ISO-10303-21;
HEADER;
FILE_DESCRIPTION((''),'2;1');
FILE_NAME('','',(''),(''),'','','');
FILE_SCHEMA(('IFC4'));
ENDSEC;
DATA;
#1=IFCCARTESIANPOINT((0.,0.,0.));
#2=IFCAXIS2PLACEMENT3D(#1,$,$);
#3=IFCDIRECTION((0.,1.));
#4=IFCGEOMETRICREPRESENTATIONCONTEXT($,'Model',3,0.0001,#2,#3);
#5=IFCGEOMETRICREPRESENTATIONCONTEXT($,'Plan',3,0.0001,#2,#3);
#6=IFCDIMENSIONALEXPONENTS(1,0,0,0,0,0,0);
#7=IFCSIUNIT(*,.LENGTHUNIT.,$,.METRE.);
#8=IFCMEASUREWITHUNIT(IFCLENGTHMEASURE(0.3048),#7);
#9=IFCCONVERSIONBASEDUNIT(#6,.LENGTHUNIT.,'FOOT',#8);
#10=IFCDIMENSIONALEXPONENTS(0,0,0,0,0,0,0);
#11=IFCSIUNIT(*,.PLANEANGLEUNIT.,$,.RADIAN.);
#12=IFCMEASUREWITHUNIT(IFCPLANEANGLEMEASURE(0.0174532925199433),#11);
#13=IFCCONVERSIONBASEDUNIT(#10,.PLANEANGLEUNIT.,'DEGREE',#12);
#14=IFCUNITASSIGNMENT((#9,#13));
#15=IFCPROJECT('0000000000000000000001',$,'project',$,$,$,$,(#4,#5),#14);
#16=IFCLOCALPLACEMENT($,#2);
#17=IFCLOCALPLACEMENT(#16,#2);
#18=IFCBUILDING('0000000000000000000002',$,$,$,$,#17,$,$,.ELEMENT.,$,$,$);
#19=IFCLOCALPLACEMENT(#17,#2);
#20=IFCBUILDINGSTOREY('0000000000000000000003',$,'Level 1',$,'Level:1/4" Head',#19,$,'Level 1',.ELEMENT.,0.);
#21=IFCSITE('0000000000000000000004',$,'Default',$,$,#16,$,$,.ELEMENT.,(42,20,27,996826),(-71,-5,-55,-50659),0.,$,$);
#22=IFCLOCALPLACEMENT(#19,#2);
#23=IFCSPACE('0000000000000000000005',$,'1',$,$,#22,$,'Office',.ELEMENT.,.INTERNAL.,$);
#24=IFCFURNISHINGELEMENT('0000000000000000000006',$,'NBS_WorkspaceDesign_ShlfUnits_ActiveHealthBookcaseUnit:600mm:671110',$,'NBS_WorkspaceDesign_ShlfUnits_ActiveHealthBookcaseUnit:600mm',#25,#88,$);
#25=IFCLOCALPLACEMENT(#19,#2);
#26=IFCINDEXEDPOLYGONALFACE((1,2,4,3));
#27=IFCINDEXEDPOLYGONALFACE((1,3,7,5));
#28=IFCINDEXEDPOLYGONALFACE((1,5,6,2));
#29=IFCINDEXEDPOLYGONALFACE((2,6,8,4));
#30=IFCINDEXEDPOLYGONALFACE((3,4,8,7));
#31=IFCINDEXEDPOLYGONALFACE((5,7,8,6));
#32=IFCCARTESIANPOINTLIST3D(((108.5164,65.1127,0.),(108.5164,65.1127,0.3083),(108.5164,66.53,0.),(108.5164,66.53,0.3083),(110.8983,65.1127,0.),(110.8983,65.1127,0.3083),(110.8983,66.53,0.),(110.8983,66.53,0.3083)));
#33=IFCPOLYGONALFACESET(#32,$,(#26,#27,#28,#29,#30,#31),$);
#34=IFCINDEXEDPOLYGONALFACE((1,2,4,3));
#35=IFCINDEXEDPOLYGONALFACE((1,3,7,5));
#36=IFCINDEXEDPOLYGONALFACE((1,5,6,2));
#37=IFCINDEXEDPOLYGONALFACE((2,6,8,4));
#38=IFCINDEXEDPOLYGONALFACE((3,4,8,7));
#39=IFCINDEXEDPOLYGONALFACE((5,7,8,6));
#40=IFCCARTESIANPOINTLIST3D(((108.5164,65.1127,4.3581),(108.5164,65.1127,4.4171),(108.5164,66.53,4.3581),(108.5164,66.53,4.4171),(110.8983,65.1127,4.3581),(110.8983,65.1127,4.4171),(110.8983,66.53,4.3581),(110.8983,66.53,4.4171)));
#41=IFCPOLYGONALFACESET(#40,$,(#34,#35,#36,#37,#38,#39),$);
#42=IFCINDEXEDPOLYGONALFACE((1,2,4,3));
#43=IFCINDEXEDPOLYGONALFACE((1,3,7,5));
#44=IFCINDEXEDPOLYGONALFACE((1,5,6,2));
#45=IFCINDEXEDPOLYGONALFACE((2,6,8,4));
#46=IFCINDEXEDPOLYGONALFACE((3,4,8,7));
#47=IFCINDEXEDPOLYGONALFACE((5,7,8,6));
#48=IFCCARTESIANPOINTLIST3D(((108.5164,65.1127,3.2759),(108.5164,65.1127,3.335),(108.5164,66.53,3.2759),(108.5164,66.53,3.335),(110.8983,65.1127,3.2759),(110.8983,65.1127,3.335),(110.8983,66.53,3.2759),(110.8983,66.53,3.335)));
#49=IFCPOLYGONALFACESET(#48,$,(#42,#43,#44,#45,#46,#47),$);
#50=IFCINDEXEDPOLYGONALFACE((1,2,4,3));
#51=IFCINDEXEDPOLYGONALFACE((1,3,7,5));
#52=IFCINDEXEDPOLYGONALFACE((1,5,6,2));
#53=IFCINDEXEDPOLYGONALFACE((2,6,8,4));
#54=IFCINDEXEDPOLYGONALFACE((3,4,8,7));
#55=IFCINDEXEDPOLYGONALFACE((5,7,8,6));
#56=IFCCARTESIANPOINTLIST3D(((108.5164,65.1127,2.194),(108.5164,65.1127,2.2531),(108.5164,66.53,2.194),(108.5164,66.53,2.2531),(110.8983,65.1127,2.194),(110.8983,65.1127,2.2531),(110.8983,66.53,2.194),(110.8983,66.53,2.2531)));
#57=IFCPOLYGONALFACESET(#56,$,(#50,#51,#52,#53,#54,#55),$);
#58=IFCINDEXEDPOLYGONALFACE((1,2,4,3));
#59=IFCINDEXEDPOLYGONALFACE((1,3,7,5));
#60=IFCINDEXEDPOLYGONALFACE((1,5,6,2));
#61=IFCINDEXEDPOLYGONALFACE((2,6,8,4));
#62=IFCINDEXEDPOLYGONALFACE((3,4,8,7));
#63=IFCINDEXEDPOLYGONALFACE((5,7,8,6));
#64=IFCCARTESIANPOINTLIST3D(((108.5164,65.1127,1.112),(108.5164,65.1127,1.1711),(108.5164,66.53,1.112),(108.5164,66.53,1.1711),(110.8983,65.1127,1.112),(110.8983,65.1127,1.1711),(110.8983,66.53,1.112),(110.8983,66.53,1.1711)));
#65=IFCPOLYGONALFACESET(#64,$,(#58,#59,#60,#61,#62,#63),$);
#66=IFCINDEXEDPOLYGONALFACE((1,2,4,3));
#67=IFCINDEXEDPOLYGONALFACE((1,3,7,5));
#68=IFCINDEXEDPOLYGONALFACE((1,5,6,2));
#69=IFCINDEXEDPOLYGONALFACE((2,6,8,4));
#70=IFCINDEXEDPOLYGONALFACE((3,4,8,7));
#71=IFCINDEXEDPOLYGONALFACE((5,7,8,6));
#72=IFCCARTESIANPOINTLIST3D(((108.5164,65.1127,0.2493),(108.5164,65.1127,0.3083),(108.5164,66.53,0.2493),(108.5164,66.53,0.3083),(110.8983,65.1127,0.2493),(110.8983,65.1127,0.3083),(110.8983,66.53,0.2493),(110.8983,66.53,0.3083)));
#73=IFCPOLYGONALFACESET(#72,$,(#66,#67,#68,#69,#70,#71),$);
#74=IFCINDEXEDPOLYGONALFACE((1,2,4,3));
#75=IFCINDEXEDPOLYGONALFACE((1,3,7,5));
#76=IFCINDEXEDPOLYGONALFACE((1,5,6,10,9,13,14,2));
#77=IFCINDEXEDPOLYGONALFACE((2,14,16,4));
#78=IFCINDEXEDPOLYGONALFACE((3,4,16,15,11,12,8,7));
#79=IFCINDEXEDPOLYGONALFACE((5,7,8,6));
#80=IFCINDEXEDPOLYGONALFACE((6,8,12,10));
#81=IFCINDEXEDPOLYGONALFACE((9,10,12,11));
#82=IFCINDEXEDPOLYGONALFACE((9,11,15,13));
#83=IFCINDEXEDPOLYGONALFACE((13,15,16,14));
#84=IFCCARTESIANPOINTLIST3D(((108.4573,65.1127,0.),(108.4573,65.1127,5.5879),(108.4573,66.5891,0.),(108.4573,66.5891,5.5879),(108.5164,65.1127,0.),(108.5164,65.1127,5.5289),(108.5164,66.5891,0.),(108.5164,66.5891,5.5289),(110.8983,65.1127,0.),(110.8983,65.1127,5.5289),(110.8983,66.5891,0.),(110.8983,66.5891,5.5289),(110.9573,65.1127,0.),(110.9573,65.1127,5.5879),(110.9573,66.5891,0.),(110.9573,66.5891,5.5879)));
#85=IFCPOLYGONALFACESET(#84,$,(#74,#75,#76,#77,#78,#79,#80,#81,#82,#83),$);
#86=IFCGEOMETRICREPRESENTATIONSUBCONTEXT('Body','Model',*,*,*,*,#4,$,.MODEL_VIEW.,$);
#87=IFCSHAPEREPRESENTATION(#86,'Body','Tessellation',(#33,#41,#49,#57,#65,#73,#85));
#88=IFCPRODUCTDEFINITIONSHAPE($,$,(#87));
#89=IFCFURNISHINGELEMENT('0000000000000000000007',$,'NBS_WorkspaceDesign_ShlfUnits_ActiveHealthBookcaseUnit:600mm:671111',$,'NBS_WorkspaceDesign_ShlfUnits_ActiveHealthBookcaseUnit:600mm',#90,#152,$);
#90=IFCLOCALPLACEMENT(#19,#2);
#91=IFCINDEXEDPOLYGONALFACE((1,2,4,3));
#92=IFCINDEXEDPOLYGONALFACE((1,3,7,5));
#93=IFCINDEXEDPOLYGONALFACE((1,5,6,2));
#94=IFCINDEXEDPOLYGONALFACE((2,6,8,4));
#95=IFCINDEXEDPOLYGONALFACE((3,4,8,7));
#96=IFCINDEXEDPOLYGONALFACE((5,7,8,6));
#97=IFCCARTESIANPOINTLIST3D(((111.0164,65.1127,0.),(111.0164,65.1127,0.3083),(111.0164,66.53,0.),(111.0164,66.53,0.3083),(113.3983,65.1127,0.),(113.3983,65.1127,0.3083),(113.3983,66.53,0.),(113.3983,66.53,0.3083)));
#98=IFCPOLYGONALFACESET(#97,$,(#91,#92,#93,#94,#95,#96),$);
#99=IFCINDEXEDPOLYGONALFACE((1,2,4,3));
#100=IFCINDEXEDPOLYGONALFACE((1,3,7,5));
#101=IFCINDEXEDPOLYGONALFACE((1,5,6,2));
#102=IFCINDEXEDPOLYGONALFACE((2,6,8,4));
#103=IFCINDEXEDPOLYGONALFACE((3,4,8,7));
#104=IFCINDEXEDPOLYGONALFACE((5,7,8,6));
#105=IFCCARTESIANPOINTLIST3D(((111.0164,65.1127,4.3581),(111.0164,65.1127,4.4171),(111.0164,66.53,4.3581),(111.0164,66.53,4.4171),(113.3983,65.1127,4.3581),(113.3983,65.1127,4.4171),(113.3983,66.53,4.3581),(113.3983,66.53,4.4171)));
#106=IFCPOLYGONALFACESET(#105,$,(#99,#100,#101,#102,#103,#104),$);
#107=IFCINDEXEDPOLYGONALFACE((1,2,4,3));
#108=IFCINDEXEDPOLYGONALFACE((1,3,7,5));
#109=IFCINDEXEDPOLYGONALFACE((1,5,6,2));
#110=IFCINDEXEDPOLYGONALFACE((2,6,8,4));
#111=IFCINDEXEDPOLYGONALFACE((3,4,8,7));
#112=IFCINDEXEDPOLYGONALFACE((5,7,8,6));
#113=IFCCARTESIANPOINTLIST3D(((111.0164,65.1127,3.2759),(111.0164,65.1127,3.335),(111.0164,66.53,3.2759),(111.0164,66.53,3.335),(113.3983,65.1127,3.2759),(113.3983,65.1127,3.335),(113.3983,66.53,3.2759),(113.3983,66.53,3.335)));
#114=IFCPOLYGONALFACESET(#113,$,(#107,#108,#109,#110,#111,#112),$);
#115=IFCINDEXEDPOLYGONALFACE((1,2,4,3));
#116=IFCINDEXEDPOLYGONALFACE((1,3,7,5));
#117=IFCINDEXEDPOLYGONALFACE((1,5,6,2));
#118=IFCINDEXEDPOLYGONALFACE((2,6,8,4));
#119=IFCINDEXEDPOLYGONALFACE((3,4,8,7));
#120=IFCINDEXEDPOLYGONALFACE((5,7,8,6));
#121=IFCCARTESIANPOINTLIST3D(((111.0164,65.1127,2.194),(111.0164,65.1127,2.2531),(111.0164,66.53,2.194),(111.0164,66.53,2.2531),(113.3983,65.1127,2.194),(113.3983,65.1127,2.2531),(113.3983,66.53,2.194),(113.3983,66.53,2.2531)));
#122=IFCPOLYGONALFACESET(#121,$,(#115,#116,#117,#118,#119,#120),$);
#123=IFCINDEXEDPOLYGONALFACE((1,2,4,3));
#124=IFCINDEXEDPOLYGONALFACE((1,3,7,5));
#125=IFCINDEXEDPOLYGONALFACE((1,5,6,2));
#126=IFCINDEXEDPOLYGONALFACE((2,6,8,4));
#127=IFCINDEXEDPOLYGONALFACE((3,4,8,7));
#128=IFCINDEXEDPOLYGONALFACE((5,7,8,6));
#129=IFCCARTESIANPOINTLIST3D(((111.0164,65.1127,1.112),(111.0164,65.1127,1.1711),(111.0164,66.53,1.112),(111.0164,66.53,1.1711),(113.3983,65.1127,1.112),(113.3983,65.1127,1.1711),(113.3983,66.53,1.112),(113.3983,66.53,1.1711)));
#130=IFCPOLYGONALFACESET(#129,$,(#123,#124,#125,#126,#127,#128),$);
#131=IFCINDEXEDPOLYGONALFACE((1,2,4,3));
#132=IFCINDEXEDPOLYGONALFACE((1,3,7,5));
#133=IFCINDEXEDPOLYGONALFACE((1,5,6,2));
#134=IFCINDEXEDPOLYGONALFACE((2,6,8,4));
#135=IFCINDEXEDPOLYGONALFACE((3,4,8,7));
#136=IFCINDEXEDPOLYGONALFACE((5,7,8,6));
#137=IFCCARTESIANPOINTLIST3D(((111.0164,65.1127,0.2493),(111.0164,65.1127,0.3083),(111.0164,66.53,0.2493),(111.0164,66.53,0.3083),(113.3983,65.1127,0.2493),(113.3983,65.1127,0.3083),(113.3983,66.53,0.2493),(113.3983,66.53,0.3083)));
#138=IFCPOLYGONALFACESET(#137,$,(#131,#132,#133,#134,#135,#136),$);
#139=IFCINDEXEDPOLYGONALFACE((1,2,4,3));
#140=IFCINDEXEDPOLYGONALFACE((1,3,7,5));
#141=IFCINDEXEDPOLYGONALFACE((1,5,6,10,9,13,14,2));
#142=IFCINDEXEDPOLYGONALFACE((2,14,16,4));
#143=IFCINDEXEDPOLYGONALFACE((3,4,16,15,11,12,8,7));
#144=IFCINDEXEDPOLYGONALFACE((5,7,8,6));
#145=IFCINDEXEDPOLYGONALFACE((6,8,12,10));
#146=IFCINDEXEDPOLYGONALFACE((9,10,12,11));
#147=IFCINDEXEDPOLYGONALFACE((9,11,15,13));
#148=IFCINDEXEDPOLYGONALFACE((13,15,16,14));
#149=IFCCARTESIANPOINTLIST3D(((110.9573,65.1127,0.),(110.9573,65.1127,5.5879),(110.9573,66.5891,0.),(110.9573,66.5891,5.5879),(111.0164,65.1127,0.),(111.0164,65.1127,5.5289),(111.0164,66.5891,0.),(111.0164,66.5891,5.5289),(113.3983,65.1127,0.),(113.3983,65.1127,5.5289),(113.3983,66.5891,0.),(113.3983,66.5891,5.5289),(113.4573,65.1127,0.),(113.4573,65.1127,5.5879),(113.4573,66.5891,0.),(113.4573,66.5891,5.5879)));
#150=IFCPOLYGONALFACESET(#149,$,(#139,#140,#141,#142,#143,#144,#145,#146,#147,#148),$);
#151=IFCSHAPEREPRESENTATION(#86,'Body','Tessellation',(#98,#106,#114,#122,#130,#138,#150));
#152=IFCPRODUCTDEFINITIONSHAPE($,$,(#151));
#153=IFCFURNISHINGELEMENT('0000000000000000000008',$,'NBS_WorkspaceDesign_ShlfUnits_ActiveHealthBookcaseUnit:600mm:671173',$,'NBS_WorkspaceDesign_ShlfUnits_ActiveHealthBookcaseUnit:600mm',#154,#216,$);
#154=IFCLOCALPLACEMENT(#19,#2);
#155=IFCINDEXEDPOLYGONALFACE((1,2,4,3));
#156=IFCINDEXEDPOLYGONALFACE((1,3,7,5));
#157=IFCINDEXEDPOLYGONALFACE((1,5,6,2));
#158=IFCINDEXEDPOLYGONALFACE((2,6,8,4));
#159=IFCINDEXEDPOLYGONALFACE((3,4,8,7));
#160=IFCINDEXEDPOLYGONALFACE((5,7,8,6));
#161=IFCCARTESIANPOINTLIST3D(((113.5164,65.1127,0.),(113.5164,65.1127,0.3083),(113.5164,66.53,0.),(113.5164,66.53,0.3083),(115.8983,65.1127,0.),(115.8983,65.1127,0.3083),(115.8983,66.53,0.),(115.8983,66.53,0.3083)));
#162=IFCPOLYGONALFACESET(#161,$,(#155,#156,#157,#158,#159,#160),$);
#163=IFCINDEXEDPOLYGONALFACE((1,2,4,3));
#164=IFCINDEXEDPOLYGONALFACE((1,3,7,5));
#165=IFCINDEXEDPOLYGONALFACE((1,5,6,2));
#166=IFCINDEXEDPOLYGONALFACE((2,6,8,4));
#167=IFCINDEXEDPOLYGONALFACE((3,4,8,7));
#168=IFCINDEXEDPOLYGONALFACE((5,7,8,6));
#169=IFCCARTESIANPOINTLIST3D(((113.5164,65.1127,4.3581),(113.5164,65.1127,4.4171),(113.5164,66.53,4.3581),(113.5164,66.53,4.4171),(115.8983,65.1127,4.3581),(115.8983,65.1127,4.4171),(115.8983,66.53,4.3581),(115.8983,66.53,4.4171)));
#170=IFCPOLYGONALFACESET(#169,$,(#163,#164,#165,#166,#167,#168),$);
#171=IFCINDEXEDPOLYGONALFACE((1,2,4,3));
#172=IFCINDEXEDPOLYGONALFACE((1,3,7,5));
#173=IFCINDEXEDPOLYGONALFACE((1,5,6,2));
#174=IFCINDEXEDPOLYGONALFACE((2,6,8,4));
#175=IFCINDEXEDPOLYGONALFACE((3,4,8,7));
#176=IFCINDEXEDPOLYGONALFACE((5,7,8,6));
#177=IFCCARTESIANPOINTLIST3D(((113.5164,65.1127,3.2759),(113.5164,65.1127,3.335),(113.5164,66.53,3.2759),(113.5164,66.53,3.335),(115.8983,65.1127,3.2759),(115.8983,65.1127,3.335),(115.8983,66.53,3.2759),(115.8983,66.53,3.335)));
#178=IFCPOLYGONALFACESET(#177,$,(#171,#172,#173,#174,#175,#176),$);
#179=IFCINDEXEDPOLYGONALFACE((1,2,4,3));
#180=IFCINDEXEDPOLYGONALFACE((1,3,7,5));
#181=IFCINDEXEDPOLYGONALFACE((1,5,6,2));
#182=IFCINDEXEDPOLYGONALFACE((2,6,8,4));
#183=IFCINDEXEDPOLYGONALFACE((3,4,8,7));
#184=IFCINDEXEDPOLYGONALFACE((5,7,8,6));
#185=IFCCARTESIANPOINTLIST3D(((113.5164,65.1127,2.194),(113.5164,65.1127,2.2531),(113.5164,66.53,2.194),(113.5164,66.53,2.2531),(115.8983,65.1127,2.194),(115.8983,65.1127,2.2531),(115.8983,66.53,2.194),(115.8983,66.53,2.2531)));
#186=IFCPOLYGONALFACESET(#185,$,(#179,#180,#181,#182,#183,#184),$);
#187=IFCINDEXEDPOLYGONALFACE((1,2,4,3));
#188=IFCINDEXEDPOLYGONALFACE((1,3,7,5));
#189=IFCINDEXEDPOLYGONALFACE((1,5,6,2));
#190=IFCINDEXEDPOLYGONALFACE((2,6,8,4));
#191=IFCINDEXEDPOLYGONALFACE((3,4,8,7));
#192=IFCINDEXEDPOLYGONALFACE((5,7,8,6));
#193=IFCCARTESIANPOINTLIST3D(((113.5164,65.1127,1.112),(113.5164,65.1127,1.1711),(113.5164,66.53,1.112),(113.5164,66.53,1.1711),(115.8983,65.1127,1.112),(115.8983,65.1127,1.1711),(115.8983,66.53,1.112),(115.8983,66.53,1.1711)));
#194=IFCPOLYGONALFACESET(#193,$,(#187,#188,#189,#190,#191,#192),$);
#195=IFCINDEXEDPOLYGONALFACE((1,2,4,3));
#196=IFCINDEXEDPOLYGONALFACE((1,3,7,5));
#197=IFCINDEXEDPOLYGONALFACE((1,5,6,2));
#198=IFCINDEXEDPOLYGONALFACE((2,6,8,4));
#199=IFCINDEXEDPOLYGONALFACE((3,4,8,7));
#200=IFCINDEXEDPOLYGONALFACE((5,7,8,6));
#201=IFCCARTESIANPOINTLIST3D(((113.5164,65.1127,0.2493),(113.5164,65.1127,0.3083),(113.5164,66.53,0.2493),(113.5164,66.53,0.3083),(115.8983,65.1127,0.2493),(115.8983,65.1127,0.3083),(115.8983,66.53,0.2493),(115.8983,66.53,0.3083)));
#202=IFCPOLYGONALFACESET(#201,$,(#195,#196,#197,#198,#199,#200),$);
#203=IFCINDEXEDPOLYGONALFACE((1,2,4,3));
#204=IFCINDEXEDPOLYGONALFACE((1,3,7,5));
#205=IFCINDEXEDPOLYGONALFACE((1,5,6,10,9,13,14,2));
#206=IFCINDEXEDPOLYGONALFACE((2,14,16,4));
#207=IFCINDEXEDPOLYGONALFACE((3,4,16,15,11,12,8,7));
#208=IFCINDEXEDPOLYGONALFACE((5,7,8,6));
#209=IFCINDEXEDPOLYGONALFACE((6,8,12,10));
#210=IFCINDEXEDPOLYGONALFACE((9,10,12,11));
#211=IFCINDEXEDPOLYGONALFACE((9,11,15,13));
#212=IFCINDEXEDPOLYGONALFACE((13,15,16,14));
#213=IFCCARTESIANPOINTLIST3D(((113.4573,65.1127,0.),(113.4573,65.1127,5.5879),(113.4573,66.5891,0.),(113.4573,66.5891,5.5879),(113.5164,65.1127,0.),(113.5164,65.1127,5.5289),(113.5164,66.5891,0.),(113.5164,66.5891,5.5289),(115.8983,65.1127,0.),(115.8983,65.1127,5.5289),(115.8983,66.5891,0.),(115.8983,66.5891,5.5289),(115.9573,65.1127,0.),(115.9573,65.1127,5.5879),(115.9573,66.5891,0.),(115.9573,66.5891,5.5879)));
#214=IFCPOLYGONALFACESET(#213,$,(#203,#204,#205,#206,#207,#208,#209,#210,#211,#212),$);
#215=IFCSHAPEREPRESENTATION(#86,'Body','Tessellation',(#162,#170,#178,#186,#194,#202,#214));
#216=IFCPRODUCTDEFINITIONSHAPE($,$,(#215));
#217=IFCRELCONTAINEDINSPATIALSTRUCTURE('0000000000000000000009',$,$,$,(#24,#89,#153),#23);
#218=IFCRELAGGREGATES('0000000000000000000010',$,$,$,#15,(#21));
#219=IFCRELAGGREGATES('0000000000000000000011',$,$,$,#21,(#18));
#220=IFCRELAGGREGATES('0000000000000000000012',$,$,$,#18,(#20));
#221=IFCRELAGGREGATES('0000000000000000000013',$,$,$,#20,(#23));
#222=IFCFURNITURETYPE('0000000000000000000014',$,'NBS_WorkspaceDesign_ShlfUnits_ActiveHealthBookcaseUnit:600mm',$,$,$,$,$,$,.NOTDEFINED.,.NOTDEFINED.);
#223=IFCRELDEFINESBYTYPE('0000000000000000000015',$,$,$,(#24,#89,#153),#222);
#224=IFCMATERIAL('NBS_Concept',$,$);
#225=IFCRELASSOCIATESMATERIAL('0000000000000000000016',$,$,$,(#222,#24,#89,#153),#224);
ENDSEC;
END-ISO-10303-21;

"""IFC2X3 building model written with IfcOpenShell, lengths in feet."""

from ifc_helpers import new_model, entity, si_unit, converted_unit, direction, frame, frame_2d, origin, place, context, subcontext, project, spatial, polyline, rectangle, outline, extrude, source, transform, mapped, material, type_object, type_shapes, element, save


model = new_model("IFC2X3")

# Units and contexts
model_context = context("Model", 3, precision=0.0001, world=origin(), true_north=direction((0.0, 1.0)))
plan_context = context("Plan", 3, precision=0.0001, world=origin(), true_north=direction((0.0, 1.0)))
body_context = subcontext(model_context, "Body", "Model", "MODEL_VIEW")
ifc_project = project(units=[converted_unit("LENGTHUNIT", "FOOT", entity("IfcLengthMeasure", 0.3048), si_unit("LENGTHUNIT", "METRE"), dimensions=[1, 0, 0, 0, 0, 0, 0]), converted_unit("PLANEANGLEUNIT", "DEGREE", entity("IfcPlaneAngleMeasure", 0.0174532925199433), si_unit("PLANEANGLEUNIT", "RADIAN"), dimensions=[0, 0, 0, 0, 0, 0, 0])], contexts=[model_context, plan_context])

# Site, building, storey
site_placement = place(None, origin())
site = spatial("IfcSite", under=ifc_project, at=site_placement, Name="Default", CompositionType="ELEMENT", RefLatitude=(42, 20, 27, 996826), RefLongitude=(-71, -5, -55, -50659), RefElevation=0.0)
building_placement = place(site_placement, origin())
building = spatial("IfcBuilding", under=site, at=building_placement, CompositionType="ELEMENT")
storey_placement = place(building_placement, origin())
storey = spatial("IfcBuildingStorey", under=building, at=storey_placement, Name="Level 1", ObjectType="Level:1/4\" Head", LongName="Level 1", CompositionType="ELEMENT", Elevation=0.0)

# Shared definitions
space_placement = place(storey_placement, origin())
space = spatial("IfcSpace", under=storey, at=space_placement, Name="1", LongName="Office", CompositionType="ELEMENT", InteriorOrExteriorSpace="INTERNAL")

# Furnishing elements
ifc_material_1 = material(Name="NBS_Concept")
furniture_type_1 = type_object("IfcFurnitureType", Name="NBS_WorkspaceDesign_ShlfUnits_ActiveHealthBookcaseUnit:600mm", AssemblyPlace="NOTDEFINED", material=ifc_material_1)
shared_shape_1 = source(origin(), body_context, "Body", "SweptSolid", [
    extrude(rectangle(XDim=1.4173, YDim=2.3819, at=frame_2d((0.0, 0.0), x_axis=(1.0, 0.0))), frame((0.0, -0.7677, 0.0), z_axis=(0.0, 0.0, 1.0), x_axis=(0.0, 1.0, 0.0)), (0.0, 0.0, 1.0), 0.3083),
    extrude(rectangle(XDim=1.4173, YDim=2.3819, at=frame_2d((0.0, 0.0), x_axis=(1.0, 0.0))), frame((0.0, -0.7677, 4.3581), z_axis=(0.0, 0.0, 1.0), x_axis=(0.0, 1.0, 0.0)), (0.0, 0.0, 1.0), 0.0591),
    extrude(rectangle(XDim=1.4173, YDim=2.3819, at=frame_2d((0.0, 0.0), x_axis=(1.0, 0.0))), frame((0.0, -0.7677, 3.2759), z_axis=(0.0, 0.0, 1.0), x_axis=(0.0, 1.0, 0.0)), (0.0, 0.0, 1.0), 0.0591),
    extrude(rectangle(XDim=1.4173, YDim=2.3819, at=frame_2d((0.0, 0.0), x_axis=(1.0, 0.0))), frame((0.0, -0.7677, 2.194), z_axis=(0.0, 0.0, 1.0), x_axis=(0.0, 1.0, 0.0)), (0.0, 0.0, 1.0), 0.0591),
    extrude(rectangle(XDim=1.4173, YDim=2.3819, at=frame_2d((0.0, 0.0), x_axis=(1.0, 0.0))), frame((0.0, -0.7677, 1.112), z_axis=(0.0, 0.0, 1.0), x_axis=(0.0, 1.0, 0.0)), (0.0, 0.0, 1.0), 0.0591),
    extrude(rectangle(XDim=1.4173, YDim=2.3819, at=frame_2d((0.0, 0.0), x_axis=(1.0, 0.0))), frame((0.0, -0.7677, 0.2493), z_axis=(0.0, 0.0, 1.0), x_axis=(0.0, 1.0, 0.0)), (0.0, 0.0, 1.0), 0.0591),
    extrude(outline(polyline([(-2.8087, -1.25), (2.7792, -1.25), (2.7792, -1.1909), (-2.7497, -1.1909), (-2.7497, 1.1909), (2.7792, 1.1909), (2.7792, 1.25), (-2.8087, 1.25), (-2.8087, -1.25)])), frame((0.0, -1.4764, 2.7792), z_axis=(0.0, 1.0, 0.0), x_axis=(0.0, 0.0, -1.0)), (0.0, 0.0, 1.0), 1.4764),
])
type_shapes(furniture_type_1, [shared_shape_1])
for number, where, name in (
    (1, (109.7073, 66.5891, 0.0), "NBS_WorkspaceDesign_ShlfUnits_ActiveHealthBookcaseUnit:600mm:671110"),
    (2, (112.2073, 66.5891, 0.0), "NBS_WorkspaceDesign_ShlfUnits_ActiveHealthBookcaseUnit:600mm:671111"),
    (3, (114.7073, 66.5891, 0.0), "NBS_WorkspaceDesign_ShlfUnits_ActiveHealthBookcaseUnit:600mm:671173"),
):
    element("IfcFurnishingElement", number, at=place(space_placement, frame(where)), inside=space, type_object=furniture_type_1, material=ifc_material_1, Name=name, ObjectType="NBS_WorkspaceDesign_ShlfUnits_ActiveHealthBookcaseUnit:600mm", context=body_context, shape_type="MappedRepresentation", body=[
        mapped(shared_shape_1, transform((0.0, 0.0, 0.0), scale=1.0)),
    ])

save(model, "model.ifc")
